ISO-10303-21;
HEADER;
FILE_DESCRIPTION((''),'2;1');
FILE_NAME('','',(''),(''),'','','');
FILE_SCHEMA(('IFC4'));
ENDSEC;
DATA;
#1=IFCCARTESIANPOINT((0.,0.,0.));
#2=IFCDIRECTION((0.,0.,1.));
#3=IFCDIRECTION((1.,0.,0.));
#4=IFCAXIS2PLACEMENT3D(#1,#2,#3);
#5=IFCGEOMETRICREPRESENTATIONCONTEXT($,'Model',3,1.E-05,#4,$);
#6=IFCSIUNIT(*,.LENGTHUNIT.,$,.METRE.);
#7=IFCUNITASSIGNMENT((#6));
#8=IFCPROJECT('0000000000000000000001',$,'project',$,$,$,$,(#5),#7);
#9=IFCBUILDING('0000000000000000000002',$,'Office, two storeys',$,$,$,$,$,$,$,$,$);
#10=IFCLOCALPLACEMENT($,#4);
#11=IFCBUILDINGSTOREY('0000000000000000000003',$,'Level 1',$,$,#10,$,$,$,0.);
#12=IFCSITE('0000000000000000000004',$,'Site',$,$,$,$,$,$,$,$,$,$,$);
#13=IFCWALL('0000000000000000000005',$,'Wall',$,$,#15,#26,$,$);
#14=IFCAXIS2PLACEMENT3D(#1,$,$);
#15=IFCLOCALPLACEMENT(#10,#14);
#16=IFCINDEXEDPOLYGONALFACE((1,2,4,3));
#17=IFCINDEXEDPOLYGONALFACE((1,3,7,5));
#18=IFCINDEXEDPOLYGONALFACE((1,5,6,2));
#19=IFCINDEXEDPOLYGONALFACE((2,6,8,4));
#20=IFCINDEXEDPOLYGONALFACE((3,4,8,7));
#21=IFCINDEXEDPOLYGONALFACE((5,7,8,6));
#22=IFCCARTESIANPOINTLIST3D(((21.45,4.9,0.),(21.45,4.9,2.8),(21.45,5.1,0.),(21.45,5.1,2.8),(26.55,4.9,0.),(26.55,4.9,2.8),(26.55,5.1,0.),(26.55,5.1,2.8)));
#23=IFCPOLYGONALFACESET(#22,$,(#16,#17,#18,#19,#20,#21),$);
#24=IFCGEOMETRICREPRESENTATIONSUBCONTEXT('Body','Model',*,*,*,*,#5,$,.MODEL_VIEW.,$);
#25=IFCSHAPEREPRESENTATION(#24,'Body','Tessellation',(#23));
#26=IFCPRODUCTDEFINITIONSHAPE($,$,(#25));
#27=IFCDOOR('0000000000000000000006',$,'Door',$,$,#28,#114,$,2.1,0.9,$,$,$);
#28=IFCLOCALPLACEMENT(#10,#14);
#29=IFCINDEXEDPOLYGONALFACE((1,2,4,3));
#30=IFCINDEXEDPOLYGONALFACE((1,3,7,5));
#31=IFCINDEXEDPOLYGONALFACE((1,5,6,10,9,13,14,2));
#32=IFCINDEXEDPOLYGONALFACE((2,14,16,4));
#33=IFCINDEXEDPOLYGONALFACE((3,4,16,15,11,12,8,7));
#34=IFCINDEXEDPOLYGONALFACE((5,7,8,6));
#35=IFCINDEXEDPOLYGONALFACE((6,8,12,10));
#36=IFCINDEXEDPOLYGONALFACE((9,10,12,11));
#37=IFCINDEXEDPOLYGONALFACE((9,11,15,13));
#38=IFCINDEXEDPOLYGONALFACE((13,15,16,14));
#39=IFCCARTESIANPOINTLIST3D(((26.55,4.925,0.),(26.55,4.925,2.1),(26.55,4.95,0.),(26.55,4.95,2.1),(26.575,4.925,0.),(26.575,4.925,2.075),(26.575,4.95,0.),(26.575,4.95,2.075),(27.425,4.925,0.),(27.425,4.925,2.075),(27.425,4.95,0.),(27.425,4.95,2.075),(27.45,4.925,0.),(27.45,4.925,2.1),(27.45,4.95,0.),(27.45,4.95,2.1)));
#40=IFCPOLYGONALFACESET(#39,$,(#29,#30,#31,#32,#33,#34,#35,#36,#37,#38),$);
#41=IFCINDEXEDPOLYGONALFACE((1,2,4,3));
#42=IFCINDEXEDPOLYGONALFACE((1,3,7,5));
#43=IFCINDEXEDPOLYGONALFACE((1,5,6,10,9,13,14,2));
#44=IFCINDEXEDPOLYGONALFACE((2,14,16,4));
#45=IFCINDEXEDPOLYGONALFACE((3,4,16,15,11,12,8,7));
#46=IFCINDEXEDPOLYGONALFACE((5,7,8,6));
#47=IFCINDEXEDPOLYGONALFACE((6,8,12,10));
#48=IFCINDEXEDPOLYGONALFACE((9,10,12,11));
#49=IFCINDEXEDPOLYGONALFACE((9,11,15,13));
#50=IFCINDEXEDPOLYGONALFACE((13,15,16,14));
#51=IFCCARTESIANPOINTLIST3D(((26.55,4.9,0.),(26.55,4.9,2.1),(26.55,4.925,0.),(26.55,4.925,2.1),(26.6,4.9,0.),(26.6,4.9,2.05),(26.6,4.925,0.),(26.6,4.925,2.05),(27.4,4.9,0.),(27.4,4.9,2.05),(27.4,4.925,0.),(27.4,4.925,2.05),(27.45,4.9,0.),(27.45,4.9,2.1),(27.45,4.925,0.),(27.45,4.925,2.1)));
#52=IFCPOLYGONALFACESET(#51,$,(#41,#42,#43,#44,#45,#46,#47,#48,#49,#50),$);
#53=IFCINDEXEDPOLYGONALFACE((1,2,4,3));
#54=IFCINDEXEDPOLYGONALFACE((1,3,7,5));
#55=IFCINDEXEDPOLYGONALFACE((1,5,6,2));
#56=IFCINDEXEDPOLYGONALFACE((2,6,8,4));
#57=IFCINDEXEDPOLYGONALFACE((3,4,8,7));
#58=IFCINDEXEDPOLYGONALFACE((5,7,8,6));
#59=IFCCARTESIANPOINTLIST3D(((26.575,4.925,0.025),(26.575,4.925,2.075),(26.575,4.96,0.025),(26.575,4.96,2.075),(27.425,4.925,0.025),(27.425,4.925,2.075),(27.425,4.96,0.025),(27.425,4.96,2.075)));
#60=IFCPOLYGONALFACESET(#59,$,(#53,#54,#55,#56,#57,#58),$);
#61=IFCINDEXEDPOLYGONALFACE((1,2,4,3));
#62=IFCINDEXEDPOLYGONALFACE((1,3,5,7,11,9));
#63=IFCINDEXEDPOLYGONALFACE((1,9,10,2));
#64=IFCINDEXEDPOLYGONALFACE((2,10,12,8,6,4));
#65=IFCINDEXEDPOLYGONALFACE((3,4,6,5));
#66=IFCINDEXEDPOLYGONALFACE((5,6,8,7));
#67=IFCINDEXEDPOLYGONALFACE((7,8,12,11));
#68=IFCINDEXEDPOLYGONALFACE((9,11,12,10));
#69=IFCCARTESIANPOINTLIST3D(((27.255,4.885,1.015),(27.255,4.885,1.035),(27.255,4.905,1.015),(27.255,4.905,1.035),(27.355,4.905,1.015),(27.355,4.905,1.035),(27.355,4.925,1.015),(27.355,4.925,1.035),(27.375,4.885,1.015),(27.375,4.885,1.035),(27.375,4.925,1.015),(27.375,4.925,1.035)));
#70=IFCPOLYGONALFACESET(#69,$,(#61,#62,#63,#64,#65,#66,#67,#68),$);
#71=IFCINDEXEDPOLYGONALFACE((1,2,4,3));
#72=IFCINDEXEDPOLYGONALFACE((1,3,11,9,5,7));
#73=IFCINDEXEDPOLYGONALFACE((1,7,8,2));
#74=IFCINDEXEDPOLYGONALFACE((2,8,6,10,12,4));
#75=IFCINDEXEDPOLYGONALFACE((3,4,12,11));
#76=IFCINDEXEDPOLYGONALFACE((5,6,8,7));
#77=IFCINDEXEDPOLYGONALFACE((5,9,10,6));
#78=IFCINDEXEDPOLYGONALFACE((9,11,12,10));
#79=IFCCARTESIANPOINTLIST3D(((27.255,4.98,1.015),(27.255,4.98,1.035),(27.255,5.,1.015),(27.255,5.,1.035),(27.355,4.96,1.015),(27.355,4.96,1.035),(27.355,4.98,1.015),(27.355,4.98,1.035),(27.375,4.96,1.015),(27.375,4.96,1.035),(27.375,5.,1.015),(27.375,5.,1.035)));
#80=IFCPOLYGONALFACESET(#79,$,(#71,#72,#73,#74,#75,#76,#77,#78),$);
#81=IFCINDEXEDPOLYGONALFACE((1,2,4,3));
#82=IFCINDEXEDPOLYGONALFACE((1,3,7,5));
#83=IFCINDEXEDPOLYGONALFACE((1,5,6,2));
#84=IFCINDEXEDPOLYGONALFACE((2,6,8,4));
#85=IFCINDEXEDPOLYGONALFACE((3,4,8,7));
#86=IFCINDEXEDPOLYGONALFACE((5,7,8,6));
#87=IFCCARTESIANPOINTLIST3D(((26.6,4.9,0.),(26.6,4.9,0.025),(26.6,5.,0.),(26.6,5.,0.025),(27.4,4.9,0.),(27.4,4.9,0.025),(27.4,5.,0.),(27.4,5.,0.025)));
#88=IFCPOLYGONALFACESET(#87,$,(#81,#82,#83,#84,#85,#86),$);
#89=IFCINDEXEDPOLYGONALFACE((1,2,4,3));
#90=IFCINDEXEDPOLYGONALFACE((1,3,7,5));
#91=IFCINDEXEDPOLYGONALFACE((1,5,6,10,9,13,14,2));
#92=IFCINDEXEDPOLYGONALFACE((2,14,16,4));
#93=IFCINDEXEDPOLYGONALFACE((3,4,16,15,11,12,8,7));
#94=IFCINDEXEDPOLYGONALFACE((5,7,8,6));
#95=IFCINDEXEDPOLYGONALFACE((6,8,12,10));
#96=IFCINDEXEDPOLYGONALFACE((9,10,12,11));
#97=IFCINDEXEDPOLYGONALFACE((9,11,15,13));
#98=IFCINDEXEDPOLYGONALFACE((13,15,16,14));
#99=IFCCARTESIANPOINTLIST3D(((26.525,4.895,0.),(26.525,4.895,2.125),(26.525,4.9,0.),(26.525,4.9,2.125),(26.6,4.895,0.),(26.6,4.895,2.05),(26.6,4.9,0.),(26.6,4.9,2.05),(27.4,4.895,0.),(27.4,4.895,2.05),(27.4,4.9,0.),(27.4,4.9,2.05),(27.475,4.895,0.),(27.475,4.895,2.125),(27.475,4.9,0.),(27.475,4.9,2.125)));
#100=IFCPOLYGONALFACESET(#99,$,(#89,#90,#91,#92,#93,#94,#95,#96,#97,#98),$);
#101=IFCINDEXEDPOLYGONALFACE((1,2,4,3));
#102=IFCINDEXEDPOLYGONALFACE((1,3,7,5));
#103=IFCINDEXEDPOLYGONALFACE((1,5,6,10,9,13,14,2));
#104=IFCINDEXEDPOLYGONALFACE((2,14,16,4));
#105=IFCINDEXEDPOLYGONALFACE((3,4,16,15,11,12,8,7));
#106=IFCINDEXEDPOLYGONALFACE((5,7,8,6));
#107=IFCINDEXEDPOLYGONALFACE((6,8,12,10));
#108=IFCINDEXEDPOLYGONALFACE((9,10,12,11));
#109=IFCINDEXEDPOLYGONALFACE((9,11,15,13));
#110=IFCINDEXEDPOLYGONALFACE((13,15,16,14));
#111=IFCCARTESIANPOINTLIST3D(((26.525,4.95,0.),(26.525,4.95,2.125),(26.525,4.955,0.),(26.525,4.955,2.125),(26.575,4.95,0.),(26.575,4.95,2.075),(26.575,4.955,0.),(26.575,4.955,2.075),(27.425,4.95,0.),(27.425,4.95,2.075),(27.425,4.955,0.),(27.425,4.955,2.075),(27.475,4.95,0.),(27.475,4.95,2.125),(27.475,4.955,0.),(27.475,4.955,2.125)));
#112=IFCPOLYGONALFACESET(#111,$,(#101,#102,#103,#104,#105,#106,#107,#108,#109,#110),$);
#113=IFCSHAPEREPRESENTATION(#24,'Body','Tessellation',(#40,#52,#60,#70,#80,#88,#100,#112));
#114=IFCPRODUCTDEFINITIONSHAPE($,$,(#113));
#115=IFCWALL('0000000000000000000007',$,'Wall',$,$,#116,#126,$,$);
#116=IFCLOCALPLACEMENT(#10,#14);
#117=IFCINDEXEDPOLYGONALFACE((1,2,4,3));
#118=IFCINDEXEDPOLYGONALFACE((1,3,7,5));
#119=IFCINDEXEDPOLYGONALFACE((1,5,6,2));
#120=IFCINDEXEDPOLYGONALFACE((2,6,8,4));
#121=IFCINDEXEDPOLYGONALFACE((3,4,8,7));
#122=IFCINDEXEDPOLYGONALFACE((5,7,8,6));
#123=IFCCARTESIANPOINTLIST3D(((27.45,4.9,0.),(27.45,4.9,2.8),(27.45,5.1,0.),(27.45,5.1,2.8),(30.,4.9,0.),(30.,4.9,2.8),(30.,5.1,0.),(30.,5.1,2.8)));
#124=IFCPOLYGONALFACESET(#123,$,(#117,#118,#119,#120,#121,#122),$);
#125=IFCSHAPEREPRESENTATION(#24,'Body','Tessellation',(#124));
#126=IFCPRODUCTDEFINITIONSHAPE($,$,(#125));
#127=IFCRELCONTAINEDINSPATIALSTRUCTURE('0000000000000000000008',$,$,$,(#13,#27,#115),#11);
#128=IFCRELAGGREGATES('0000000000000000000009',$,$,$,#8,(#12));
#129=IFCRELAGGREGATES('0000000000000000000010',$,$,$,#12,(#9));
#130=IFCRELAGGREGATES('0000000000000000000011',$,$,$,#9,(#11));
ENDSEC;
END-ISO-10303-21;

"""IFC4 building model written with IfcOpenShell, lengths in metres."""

from ifc_helpers import new_model, si_unit, frame, origin_with_axes, place, context, subcontext, project, spatial, line, indexed_curve, outline, extrude, element, save


model = new_model("IFC4")

# Units and contexts
model_context = context("Model", 3, precision=1e-05, world=origin_with_axes())
body_context = subcontext(model_context, "Body", "Model", "MODEL_VIEW")
ifc_project = project(units=[si_unit("LENGTHUNIT", "METRE")], contexts=[model_context])

# Site, building, storey
site = spatial("IfcSite", under=ifc_project, Name="Site")
building = spatial("IfcBuilding", under=site, Name="Office, two storeys")
storey_placement = place(None, origin_with_axes())
storey = spatial("IfcBuildingStorey", under=building, at=storey_placement, Name="Level 1", Elevation=0.0)

# Wall
wall_1_placement = place(storey_placement, frame((21.45, 5.0, 0.0), z_axis=(0.0, 0.0, 1.0), x_axis=(1.0, 0.0, 0.0)))
element("IfcWall", 1, at=wall_1_placement, inside=storey, Name="Wall", context=body_context, shape_type="SweptSolid", body=[
    extrude(outline(indexed_curve([(0.0, 0.0), (0.0, 0.2), (5.1, 0.2), (5.1, 0.0), (0.0, 0.0)], self_intersect=False)), frame((0.0, -0.1, 0.0), z_axis=(0.0, 0.0, 1.0), x_axis=(1.0, 0.0, 0.0)), (0.0, 0.0, 1.0), 2.8),
])

# Door
door_1_placement = place(storey_placement, frame((26.55, 4.9, 0.0), z_axis=(0.0, 0.0, 1.0), x_axis=(1.0, 0.0, 0.0)))
element("IfcDoor", 2, at=door_1_placement, inside=storey, Name="Door", OverallHeight=2.1, OverallWidth=0.9, context=body_context, shape_type="SweptSolid", body=[
    extrude(outline(indexed_curve([(0.0, 0.0), (0.0, 2.1), (0.9, 2.1), (0.9, 0.0), (0.875, 0.0), (0.875, 2.075), (0.025, 2.075), (0.025, 0.0)], segments=[line(1, 2, 3, 4, 5, 6, 7, 8, 1)])), frame((0.0, 0.025, 0.0), z_axis=(0.0, -1.0, 0.0), x_axis=(1.0, 0.0, 0.0)), (0.0, 0.0, -1.0), 0.025),
    extrude(outline(indexed_curve([(0.0, 0.0), (0.0, 2.1), (0.9, 2.1), (0.9, 0.0), (0.85, 0.0), (0.85, 2.05), (0.05, 2.05), (0.05, 0.0)], segments=[line(1, 2, 3, 4, 5, 6, 7, 8, 1)])), frame((0.0, 0.0, 0.0), z_axis=(0.0, -1.0, 0.0), x_axis=(1.0, 0.0, 0.0)), (0.0, 0.0, -1.0), 0.025),
    extrude(outline(indexed_curve([(0.0, 0.0), (0.85, 0.0), (0.85, 0.035), (0.0, 0.035)], segments=[line(1, 2, 3, 4, 1)])), frame((0.025, 0.025, 0.025), z_axis=(0.0, 0.0, 1.0), x_axis=(1.0, 0.0, 0.0)), (0.0, 0.0, 1.0), 2.05),
    extrude(outline(indexed_curve([(0.0, 0.0), (0.0, -0.04), (-0.12, -0.04), (-0.12, -0.02), (-0.02, -0.02), (-0.02, 0.0)], segments=[line(1, 2, 3, 4, 5, 6, 1)])), frame((0.825, 0.025, 1.015), z_axis=(0.0, 0.0, 1.0), x_axis=(1.0, 0.0, 0.0)), (0.0, 0.0, 1.0), 0.02),
    extrude(outline(indexed_curve([(0.0, 0.0), (0.0, 0.04), (-0.12, 0.04), (-0.12, 0.02), (-0.02, 0.02), (-0.02, 0.0)], segments=[line(1, 2, 3, 4, 5, 6, 1)])), frame((0.825, 0.06, 1.015), z_axis=(0.0, 0.0, 1.0), x_axis=(1.0, 0.0, 0.0)), (0.0, 0.0, 1.0), 0.02),
    extrude(outline(indexed_curve([(0.0, 0.0), (0.8, 0.0), (0.8, 0.1), (0.0, 0.1)], segments=[line(1, 2, 3, 4, 1)])), frame((0.05, 0.0, 0.0), z_axis=(0.0, 0.0, 1.0), x_axis=(1.0, 0.0, 0.0)), (0.0, 0.0, 1.0), 0.025),
    extrude(outline(indexed_curve([(0.0, 0.0), (0.0, 2.125), (0.95, 2.125), (0.95, 0.0), (0.875, 0.0), (0.875, 2.05), (0.075, 2.05), (0.075, 0.0)], segments=[line(1, 2, 3, 4, 5, 6, 7, 8, 1)])), frame((-0.025, -0.005, 0.0), z_axis=(0.0, -1.0, 0.0), x_axis=(1.0, 0.0, 0.0)), (0.0, 0.0, -1.0), 0.005),
    extrude(outline(indexed_curve([(0.0, 0.0), (0.0, 2.125), (0.95, 2.125), (0.95, 0.0), (0.9, 0.0), (0.9, 2.075), (0.05, 2.075), (0.05, 0.0)], segments=[line(1, 2, 3, 4, 5, 6, 7, 8, 1)])), frame((-0.025, 0.05, 0.0), z_axis=(0.0, -1.0, 0.0), x_axis=(1.0, 0.0, 0.0)), (0.0, 0.0, -1.0), 0.005),
])

# Wall
wall_2_placement = place(storey_placement, frame((27.45, 5.0, 0.0), z_axis=(0.0, 0.0, 1.0), x_axis=(1.0, 0.0, 0.0)))
element("IfcWall", 3, at=wall_2_placement, inside=storey, Name="Wall", context=body_context, shape_type="SweptSolid", body=[
    extrude(outline(indexed_curve([(0.0, 0.0), (0.0, 0.2), (2.55, 0.2), (2.55, 0.0), (0.0, 0.0)], self_intersect=False)), frame((0.0, -0.1, 0.0), z_axis=(0.0, 0.0, 1.0), x_axis=(1.0, 0.0, 0.0)), (0.0, 0.0, 1.0), 2.8),
])

save(model, "model.ifc")
